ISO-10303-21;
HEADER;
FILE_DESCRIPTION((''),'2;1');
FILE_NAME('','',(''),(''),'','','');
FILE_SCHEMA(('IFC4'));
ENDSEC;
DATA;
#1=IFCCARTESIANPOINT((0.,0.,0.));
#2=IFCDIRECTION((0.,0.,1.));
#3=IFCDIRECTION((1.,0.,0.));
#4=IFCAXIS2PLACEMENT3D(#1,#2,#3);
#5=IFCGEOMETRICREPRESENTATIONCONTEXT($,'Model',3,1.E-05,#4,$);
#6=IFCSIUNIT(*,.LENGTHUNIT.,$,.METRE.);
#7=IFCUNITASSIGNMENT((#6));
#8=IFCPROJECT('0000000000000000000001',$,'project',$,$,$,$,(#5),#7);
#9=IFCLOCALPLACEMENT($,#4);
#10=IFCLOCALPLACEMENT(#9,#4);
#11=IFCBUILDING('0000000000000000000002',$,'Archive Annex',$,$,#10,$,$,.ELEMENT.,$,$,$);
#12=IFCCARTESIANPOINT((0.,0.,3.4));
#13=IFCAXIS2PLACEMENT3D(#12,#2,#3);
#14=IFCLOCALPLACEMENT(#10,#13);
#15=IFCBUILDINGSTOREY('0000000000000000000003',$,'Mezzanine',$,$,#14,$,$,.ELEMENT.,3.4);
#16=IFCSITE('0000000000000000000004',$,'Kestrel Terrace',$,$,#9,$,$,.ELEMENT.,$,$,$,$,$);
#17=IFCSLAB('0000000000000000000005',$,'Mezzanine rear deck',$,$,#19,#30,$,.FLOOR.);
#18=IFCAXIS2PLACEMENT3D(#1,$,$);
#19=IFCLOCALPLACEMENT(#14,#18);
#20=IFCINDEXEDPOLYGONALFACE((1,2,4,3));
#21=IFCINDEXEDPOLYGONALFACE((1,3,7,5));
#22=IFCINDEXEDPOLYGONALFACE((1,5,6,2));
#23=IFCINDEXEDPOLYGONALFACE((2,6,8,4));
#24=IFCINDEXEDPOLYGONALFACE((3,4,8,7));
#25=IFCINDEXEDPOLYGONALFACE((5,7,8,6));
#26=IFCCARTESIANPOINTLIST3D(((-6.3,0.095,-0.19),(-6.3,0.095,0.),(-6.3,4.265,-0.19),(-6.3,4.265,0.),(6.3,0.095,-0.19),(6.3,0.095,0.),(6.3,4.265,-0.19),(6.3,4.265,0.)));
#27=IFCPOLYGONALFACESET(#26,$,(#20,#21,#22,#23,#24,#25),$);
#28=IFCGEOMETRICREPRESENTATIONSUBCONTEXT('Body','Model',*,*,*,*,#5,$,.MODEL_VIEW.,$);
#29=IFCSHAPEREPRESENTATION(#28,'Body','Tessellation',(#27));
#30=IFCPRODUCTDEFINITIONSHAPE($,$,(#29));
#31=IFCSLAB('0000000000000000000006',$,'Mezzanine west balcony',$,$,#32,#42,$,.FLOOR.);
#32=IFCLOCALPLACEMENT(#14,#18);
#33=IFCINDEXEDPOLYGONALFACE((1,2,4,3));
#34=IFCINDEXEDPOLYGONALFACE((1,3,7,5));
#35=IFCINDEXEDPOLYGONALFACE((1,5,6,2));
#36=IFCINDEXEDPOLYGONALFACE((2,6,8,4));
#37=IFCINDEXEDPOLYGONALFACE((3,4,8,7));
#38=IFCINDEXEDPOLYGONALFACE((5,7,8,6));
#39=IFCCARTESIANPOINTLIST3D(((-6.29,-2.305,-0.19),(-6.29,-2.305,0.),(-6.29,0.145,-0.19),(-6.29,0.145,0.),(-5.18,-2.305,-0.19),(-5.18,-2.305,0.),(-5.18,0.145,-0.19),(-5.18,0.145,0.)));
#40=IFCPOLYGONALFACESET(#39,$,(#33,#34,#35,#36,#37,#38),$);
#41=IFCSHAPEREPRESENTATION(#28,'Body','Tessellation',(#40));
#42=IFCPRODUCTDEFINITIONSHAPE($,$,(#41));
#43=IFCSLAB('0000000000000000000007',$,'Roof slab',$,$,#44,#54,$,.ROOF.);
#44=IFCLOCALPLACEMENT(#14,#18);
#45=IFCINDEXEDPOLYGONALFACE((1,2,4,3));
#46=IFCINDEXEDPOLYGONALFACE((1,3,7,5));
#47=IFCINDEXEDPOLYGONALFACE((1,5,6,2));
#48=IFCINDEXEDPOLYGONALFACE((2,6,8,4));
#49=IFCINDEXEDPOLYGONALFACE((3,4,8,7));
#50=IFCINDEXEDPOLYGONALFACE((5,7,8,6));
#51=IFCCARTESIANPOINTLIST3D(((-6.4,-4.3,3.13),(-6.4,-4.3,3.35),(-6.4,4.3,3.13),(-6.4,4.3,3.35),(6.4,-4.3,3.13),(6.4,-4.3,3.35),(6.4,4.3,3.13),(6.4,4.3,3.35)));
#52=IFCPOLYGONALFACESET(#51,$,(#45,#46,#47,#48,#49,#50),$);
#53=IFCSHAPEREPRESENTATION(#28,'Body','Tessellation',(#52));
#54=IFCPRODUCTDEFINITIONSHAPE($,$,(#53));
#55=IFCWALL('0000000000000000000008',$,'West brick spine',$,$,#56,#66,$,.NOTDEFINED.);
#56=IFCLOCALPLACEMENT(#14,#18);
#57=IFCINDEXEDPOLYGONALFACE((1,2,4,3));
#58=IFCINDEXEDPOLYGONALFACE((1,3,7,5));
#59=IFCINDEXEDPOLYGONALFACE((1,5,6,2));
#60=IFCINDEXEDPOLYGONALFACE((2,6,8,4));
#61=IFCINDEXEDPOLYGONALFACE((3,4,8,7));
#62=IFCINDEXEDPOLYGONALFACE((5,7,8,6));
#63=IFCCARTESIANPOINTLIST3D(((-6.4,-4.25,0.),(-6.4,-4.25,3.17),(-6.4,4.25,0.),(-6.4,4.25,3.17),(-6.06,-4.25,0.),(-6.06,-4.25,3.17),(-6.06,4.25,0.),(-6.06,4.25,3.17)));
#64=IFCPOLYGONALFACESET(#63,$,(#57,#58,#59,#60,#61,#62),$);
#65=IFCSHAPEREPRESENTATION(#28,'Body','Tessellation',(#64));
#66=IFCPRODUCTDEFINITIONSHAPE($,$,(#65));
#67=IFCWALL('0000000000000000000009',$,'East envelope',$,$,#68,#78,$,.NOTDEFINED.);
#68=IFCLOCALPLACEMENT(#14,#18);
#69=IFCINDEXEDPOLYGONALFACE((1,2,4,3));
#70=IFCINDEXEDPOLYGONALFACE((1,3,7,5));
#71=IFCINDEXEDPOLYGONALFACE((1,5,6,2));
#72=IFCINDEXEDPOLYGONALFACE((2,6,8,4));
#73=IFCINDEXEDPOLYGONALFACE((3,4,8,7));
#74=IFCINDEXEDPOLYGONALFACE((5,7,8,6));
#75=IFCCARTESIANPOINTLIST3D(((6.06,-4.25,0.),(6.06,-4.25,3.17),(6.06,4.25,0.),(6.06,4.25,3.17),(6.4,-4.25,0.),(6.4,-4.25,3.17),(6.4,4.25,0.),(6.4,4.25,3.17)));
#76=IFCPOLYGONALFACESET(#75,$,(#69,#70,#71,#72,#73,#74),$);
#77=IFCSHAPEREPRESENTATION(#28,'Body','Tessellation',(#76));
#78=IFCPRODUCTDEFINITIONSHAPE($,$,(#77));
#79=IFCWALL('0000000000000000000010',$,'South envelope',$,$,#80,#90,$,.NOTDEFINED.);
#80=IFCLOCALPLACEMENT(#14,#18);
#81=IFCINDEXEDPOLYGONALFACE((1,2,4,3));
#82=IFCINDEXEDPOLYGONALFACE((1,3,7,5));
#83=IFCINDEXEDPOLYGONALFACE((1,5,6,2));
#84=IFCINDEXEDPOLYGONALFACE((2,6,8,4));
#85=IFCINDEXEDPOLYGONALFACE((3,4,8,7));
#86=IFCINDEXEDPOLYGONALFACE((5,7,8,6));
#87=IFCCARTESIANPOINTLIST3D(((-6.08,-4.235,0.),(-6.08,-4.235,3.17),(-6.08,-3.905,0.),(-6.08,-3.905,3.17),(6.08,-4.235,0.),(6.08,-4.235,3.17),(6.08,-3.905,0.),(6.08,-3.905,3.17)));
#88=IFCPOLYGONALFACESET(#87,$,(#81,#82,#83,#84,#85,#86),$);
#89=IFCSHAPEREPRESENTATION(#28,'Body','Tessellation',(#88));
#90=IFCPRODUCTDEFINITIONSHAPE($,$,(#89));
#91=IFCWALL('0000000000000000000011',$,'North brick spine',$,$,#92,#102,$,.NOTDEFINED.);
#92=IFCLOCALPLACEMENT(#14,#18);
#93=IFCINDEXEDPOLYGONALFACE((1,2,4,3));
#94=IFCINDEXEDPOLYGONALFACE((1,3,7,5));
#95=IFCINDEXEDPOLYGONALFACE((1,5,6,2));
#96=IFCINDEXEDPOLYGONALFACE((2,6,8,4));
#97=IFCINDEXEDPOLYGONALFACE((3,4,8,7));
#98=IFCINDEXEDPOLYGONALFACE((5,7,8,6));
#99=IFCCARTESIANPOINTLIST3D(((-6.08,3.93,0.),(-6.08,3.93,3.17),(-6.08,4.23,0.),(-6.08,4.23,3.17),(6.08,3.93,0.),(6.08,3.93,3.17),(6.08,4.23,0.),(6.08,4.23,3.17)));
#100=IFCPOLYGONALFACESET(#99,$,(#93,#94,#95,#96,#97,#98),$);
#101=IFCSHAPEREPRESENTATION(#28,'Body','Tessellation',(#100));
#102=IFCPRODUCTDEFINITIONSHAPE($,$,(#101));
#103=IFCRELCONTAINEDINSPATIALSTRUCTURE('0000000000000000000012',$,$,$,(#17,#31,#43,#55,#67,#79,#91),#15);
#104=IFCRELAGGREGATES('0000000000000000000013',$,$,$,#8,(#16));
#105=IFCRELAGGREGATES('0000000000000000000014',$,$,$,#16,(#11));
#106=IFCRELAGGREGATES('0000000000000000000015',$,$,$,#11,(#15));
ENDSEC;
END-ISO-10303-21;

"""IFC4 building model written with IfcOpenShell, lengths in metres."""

from ifc_helpers import new_model, si_unit, frame, origin_with_axes, origin_2d, place, context, subcontext, project, spatial, rectangle, extrude, element, save


model = new_model("IFC4")

# Units and contexts
model_context = context("Model", 3, precision=1e-05, world=origin_with_axes())
body_context = subcontext(model_context, "Body", "Model", "MODEL_VIEW")
ifc_project = project(units=[si_unit("LENGTHUNIT", "METRE")], contexts=[model_context])

# Site, building, storey
site_placement = place(None, origin_with_axes())
site = spatial("IfcSite", under=ifc_project, at=site_placement, Name="Kestrel Terrace", CompositionType="ELEMENT")
building_placement = place(site_placement, origin_with_axes())
building = spatial("IfcBuilding", under=site, at=building_placement, Name="Archive Annex", CompositionType="ELEMENT")
storey_placement = place(building_placement, frame((0.0, 0.0, 3.4), z_axis=(0.0, 0.0, 1.0), x_axis=(1.0, 0.0, 0.0)))
storey = spatial("IfcBuildingStorey", under=building, at=storey_placement, Name="Mezzanine", CompositionType="ELEMENT", Elevation=3.4)

# Slabs
slab_1_placement = place(storey_placement, frame((0.0, 2.18, -0.19), z_axis=(0.0, 0.0, 1.0), x_axis=(1.0, 0.0, 0.0)))
element("IfcSlab", 1, at=slab_1_placement, inside=storey, Name="Mezzanine rear deck", PredefinedType="FLOOR", context=body_context, shape_type="SweptSolid", body=[
    extrude(rectangle(XDim=12.6, YDim=4.17, at=origin_2d()), origin_with_axes(), (0.0, 0.0, 1.0), 0.19),
])
slab_2_placement = place(storey_placement, frame((-5.735, -1.08, -0.19), z_axis=(0.0, 0.0, 1.0), x_axis=(1.0, 0.0, 0.0)))
element("IfcSlab", 2, at=slab_2_placement, inside=storey, Name="Mezzanine west balcony", PredefinedType="FLOOR", context=body_context, shape_type="SweptSolid", body=[
    extrude(rectangle(XDim=1.11, YDim=2.45, at=origin_2d()), origin_with_axes(), (0.0, 0.0, 1.0), 0.19),
])
slab_3_placement = place(storey_placement, frame((0.0, 0.0, 3.13), z_axis=(0.0, 0.0, 1.0), x_axis=(1.0, 0.0, 0.0)))
element("IfcSlab", 3, at=slab_3_placement, inside=storey, Name="Roof slab", PredefinedType="ROOF", context=body_context, shape_type="SweptSolid", body=[
    extrude(rectangle(XDim=12.8, YDim=8.6, at=origin_2d()), origin_with_axes(), (0.0, 0.0, 1.0), 0.22),
])

# Walls
for number, where, z_axis, x_axis, name in (
    (4, (-6.23, 0.0, 0.0), (0.0, 0.0, 1.0), (1.0, 0.0, 0.0), "West brick spine"),
    (5, (6.23, 0.0, 0.0), (0.0, 0.0, 1.0), (1.0, 0.0, 0.0), "East envelope"),
):
    element("IfcWall", number, at=place(storey_placement, frame(where, z_axis=z_axis, x_axis=x_axis)), inside=storey, Name=name, PredefinedType="NOTDEFINED", context=body_context, shape_type="SweptSolid", body=[
        extrude(rectangle(XDim=0.34, YDim=8.5, at=origin_2d()), origin_with_axes(), (0.0, 0.0, 1.0), 3.17),
    ])
wall_1_placement = place(storey_placement, frame((0.0, -4.07, 0.0), z_axis=(0.0, 0.0, 1.0), x_axis=(1.0, 0.0, 0.0)))
element("IfcWall", 6, at=wall_1_placement, inside=storey, Name="South envelope", PredefinedType="NOTDEFINED", context=body_context, shape_type="SweptSolid", body=[
    extrude(rectangle(XDim=12.16, YDim=0.33, at=origin_2d()), origin_with_axes(), (0.0, 0.0, 1.0), 3.17),
])
wall_2_placement = place(storey_placement, frame((0.0, 4.08, 0.0), z_axis=(0.0, 0.0, 1.0), x_axis=(1.0, 0.0, 0.0)))
element("IfcWall", 7, at=wall_2_placement, inside=storey, Name="North brick spine", PredefinedType="NOTDEFINED", context=body_context, shape_type="SweptSolid", body=[
    extrude(rectangle(XDim=12.16, YDim=0.3, at=origin_2d()), origin_with_axes(), (0.0, 0.0, 1.0), 3.17),
])

save(model, "model.ifc")
